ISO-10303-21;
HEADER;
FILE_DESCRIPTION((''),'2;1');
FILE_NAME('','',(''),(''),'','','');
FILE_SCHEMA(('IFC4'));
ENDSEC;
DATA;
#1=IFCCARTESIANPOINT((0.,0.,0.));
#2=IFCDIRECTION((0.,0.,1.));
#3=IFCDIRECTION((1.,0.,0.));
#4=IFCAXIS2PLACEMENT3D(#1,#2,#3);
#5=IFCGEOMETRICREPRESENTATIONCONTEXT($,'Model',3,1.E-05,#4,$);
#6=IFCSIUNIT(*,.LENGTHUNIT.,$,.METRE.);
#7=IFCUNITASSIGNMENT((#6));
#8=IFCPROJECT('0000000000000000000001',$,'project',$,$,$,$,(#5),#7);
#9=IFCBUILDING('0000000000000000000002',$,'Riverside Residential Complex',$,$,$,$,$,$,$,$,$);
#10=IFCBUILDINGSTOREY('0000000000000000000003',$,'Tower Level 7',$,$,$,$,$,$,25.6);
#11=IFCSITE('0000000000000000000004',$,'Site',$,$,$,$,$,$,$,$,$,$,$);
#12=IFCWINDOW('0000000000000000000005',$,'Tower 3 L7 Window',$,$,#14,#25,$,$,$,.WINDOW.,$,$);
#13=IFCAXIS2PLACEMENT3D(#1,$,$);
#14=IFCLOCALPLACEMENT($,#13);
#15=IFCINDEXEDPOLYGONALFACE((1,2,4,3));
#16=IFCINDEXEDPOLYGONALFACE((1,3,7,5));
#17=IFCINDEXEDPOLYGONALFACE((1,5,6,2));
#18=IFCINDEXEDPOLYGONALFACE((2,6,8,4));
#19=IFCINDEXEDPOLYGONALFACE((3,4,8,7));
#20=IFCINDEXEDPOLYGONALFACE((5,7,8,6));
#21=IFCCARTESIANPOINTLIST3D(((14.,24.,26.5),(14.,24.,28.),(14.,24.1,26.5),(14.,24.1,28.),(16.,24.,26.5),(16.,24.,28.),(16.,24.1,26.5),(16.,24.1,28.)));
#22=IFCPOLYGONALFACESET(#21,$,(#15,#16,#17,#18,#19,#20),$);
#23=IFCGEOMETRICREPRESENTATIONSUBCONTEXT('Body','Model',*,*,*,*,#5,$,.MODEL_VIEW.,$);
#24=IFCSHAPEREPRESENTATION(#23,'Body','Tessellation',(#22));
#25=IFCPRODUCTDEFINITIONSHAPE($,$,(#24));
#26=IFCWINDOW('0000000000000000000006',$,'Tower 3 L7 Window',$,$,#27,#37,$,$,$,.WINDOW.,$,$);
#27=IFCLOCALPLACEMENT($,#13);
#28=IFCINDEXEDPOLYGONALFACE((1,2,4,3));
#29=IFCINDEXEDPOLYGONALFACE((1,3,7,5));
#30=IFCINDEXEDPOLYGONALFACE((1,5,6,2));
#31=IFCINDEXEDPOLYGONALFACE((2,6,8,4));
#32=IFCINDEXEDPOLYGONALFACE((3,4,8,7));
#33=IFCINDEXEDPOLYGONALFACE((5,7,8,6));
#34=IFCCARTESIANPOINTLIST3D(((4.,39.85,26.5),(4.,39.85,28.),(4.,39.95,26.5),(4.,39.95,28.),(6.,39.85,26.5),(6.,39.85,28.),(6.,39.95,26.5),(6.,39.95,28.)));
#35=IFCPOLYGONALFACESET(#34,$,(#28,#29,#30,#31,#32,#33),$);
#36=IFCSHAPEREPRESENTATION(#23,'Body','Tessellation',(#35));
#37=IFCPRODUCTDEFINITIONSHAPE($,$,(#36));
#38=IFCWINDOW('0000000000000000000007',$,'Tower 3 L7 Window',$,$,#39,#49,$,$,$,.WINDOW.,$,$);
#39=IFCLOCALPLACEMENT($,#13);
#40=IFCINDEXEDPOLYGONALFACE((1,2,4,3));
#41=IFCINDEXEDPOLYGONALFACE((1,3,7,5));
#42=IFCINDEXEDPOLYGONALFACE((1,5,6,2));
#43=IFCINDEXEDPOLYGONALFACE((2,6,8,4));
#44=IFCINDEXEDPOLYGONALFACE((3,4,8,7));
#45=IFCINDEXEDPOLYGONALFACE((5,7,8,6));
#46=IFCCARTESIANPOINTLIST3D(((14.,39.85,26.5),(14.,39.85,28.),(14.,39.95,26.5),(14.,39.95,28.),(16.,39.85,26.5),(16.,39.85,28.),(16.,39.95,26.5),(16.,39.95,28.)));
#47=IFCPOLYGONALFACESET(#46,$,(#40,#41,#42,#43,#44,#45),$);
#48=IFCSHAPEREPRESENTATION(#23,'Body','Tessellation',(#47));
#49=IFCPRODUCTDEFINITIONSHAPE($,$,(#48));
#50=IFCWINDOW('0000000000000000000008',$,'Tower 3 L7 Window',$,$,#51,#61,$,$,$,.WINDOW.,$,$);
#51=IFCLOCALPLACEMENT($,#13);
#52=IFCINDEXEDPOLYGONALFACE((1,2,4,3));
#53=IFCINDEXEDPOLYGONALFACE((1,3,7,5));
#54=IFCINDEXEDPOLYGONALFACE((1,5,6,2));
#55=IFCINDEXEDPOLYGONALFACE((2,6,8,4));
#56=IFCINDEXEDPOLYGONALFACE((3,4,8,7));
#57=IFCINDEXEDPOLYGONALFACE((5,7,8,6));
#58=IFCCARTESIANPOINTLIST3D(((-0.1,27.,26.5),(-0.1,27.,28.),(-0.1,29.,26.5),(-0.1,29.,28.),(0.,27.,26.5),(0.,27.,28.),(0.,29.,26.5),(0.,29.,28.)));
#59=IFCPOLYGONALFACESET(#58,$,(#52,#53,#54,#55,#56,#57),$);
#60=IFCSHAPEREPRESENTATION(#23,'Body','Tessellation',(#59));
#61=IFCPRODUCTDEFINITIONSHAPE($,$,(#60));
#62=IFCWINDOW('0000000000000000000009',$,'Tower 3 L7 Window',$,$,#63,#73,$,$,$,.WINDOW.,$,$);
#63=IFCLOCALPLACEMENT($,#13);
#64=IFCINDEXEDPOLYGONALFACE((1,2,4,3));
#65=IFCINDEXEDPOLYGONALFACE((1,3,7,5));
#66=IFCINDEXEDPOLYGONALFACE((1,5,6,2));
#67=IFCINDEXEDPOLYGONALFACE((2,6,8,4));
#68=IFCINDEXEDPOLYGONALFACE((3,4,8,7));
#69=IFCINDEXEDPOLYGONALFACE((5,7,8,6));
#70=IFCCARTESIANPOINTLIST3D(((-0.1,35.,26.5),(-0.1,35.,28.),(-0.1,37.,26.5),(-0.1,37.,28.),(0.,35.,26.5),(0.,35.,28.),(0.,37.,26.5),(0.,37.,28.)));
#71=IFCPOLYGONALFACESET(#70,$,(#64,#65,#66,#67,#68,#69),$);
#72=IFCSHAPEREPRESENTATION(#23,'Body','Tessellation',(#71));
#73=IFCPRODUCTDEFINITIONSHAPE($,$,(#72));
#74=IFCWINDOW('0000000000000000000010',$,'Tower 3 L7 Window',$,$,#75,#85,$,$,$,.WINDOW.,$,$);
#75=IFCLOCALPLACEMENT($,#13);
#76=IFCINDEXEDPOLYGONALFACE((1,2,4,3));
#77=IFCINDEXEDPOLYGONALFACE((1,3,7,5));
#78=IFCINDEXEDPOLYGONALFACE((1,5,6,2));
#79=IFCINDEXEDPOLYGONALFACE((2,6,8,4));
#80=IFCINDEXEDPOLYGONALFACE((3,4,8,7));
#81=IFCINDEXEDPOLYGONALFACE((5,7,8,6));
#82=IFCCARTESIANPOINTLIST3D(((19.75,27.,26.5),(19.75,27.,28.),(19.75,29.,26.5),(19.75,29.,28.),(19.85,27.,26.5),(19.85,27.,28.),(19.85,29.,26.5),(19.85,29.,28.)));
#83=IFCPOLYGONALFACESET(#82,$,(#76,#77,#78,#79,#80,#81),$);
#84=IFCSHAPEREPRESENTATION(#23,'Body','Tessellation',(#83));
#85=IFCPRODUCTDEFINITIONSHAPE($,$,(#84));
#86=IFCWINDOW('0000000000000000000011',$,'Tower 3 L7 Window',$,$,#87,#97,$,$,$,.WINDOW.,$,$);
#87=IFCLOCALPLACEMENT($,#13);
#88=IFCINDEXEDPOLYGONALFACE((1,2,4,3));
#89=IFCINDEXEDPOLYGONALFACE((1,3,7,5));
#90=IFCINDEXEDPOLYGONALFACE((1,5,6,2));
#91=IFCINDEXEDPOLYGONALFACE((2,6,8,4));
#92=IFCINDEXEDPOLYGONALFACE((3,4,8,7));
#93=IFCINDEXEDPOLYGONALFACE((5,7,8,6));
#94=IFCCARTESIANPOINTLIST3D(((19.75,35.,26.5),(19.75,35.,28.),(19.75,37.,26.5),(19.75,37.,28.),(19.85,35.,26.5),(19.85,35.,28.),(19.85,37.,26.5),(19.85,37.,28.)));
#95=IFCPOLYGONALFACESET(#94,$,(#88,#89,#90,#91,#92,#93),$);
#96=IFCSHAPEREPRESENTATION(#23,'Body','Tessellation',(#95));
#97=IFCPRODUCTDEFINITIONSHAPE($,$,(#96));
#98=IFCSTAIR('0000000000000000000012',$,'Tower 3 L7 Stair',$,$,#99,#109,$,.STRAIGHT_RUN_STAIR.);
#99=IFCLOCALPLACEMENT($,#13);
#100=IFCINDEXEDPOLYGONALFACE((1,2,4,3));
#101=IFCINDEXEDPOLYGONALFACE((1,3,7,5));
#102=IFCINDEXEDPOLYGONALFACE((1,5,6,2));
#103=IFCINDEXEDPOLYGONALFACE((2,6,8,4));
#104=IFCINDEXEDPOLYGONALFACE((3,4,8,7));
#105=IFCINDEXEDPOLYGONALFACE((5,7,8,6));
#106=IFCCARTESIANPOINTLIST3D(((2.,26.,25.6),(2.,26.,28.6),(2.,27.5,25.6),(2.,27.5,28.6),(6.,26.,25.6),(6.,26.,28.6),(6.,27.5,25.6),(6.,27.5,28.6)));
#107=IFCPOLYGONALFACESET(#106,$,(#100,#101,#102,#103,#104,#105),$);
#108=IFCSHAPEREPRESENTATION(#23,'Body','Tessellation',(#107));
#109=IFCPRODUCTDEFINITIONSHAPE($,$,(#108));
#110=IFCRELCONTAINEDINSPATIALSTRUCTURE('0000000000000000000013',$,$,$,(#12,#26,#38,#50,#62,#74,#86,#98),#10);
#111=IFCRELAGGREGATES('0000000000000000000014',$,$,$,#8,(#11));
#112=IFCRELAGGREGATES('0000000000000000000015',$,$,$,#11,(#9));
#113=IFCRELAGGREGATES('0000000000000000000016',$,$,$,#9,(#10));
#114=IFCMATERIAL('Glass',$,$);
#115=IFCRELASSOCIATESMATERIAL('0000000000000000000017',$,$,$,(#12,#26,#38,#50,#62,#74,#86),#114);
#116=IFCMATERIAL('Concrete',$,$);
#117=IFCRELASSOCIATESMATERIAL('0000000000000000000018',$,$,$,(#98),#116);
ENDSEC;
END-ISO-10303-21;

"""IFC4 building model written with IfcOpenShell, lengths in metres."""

from ifc_helpers import new_model, si_unit, frame, origin_with_axes, place, context, subcontext, project, spatial, line, indexed_curve, outline, extrude, material, element, save


model = new_model("IFC4")

# Units and contexts
model_context = context("Model", 3, precision=1e-05, world=origin_with_axes())
body_context = subcontext(model_context, "Body", "Model", "MODEL_VIEW")
ifc_project = project(units=[si_unit("LENGTHUNIT", "METRE")], contexts=[model_context])

# Site, building, storey
site = spatial("IfcSite", under=ifc_project, Name="Site")
building = spatial("IfcBuilding", under=site, Name="Riverside Residential Complex")
storey = spatial("IfcBuildingStorey", under=building, Name="Tower Level 7", Elevation=25.6)

# Shared definitions
ifc_material_1 = material(Name="Concrete")

# Windows
ifc_material_2 = material(Name="Glass")
for number, where, z_axis, x_axis, name in (
    (1, (14.0, 24.0, 26.5), (0.0, 0.0, 1.0), (1.0, 0.0, 0.0), "Tower 3 L7 Window"),
    (2, (4.0, 39.85, 26.5), (0.0, 0.0, 1.0), (1.0, 0.0, 0.0), "Tower 3 L7 Window"),
    (3, (14.0, 39.85, 26.5), (0.0, 0.0, 1.0), (1.0, 0.0, 0.0), "Tower 3 L7 Window"),
    (4, (0.0, 27.0, 26.5), (0.0, 0.0, 1.0), (0.0, 1.0, 0.0), "Tower 3 L7 Window"),
    (5, (0.0, 35.0, 26.5), (0.0, 0.0, 1.0), (0.0, 1.0, 0.0), "Tower 3 L7 Window"),
    (6, (19.85, 27.0, 26.5), (0.0, 0.0, 1.0), (0.0, 1.0, 0.0), "Tower 3 L7 Window"),
    (7, (19.85, 35.0, 26.5), (0.0, 0.0, 1.0), (0.0, 1.0, 0.0), "Tower 3 L7 Window"),
):
    element("IfcWindow", number, at=place(None, frame(where, z_axis=z_axis, x_axis=x_axis)), inside=storey, material=ifc_material_2, Name=name, PredefinedType="WINDOW", context=body_context, shape_type="SweptSolid", body=[
        extrude(outline(indexed_curve([(0.0, 0.0), (2.0, 0.0), (2.0, 0.1), (0.0, 0.1)], segments=[line(1, 2, 3, 4, 1)])), origin_with_axes(), (0.0, 0.0, 1.0), 1.5),
    ])

# Stair
stair_placement = place(None, frame((2.0, 26.0, 25.6), z_axis=(0.0, 0.0, 1.0), x_axis=(1.0, 0.0, 0.0)))
element("IfcStair", 8, at=stair_placement, inside=storey, material=ifc_material_1, Name="Tower 3 L7 Stair", PredefinedType="STRAIGHT_RUN_STAIR", context=body_context, shape_type="SweptSolid", body=[
    extrude(outline(indexed_curve([(0.0, 0.0), (4.0, 0.0), (4.0, 1.5), (0.0, 1.5)], segments=[line(1, 2, 3, 4, 1)])), origin_with_axes(), (0.0, 0.0, 1.0), 3.0),
])

save(model, "model.ifc")
